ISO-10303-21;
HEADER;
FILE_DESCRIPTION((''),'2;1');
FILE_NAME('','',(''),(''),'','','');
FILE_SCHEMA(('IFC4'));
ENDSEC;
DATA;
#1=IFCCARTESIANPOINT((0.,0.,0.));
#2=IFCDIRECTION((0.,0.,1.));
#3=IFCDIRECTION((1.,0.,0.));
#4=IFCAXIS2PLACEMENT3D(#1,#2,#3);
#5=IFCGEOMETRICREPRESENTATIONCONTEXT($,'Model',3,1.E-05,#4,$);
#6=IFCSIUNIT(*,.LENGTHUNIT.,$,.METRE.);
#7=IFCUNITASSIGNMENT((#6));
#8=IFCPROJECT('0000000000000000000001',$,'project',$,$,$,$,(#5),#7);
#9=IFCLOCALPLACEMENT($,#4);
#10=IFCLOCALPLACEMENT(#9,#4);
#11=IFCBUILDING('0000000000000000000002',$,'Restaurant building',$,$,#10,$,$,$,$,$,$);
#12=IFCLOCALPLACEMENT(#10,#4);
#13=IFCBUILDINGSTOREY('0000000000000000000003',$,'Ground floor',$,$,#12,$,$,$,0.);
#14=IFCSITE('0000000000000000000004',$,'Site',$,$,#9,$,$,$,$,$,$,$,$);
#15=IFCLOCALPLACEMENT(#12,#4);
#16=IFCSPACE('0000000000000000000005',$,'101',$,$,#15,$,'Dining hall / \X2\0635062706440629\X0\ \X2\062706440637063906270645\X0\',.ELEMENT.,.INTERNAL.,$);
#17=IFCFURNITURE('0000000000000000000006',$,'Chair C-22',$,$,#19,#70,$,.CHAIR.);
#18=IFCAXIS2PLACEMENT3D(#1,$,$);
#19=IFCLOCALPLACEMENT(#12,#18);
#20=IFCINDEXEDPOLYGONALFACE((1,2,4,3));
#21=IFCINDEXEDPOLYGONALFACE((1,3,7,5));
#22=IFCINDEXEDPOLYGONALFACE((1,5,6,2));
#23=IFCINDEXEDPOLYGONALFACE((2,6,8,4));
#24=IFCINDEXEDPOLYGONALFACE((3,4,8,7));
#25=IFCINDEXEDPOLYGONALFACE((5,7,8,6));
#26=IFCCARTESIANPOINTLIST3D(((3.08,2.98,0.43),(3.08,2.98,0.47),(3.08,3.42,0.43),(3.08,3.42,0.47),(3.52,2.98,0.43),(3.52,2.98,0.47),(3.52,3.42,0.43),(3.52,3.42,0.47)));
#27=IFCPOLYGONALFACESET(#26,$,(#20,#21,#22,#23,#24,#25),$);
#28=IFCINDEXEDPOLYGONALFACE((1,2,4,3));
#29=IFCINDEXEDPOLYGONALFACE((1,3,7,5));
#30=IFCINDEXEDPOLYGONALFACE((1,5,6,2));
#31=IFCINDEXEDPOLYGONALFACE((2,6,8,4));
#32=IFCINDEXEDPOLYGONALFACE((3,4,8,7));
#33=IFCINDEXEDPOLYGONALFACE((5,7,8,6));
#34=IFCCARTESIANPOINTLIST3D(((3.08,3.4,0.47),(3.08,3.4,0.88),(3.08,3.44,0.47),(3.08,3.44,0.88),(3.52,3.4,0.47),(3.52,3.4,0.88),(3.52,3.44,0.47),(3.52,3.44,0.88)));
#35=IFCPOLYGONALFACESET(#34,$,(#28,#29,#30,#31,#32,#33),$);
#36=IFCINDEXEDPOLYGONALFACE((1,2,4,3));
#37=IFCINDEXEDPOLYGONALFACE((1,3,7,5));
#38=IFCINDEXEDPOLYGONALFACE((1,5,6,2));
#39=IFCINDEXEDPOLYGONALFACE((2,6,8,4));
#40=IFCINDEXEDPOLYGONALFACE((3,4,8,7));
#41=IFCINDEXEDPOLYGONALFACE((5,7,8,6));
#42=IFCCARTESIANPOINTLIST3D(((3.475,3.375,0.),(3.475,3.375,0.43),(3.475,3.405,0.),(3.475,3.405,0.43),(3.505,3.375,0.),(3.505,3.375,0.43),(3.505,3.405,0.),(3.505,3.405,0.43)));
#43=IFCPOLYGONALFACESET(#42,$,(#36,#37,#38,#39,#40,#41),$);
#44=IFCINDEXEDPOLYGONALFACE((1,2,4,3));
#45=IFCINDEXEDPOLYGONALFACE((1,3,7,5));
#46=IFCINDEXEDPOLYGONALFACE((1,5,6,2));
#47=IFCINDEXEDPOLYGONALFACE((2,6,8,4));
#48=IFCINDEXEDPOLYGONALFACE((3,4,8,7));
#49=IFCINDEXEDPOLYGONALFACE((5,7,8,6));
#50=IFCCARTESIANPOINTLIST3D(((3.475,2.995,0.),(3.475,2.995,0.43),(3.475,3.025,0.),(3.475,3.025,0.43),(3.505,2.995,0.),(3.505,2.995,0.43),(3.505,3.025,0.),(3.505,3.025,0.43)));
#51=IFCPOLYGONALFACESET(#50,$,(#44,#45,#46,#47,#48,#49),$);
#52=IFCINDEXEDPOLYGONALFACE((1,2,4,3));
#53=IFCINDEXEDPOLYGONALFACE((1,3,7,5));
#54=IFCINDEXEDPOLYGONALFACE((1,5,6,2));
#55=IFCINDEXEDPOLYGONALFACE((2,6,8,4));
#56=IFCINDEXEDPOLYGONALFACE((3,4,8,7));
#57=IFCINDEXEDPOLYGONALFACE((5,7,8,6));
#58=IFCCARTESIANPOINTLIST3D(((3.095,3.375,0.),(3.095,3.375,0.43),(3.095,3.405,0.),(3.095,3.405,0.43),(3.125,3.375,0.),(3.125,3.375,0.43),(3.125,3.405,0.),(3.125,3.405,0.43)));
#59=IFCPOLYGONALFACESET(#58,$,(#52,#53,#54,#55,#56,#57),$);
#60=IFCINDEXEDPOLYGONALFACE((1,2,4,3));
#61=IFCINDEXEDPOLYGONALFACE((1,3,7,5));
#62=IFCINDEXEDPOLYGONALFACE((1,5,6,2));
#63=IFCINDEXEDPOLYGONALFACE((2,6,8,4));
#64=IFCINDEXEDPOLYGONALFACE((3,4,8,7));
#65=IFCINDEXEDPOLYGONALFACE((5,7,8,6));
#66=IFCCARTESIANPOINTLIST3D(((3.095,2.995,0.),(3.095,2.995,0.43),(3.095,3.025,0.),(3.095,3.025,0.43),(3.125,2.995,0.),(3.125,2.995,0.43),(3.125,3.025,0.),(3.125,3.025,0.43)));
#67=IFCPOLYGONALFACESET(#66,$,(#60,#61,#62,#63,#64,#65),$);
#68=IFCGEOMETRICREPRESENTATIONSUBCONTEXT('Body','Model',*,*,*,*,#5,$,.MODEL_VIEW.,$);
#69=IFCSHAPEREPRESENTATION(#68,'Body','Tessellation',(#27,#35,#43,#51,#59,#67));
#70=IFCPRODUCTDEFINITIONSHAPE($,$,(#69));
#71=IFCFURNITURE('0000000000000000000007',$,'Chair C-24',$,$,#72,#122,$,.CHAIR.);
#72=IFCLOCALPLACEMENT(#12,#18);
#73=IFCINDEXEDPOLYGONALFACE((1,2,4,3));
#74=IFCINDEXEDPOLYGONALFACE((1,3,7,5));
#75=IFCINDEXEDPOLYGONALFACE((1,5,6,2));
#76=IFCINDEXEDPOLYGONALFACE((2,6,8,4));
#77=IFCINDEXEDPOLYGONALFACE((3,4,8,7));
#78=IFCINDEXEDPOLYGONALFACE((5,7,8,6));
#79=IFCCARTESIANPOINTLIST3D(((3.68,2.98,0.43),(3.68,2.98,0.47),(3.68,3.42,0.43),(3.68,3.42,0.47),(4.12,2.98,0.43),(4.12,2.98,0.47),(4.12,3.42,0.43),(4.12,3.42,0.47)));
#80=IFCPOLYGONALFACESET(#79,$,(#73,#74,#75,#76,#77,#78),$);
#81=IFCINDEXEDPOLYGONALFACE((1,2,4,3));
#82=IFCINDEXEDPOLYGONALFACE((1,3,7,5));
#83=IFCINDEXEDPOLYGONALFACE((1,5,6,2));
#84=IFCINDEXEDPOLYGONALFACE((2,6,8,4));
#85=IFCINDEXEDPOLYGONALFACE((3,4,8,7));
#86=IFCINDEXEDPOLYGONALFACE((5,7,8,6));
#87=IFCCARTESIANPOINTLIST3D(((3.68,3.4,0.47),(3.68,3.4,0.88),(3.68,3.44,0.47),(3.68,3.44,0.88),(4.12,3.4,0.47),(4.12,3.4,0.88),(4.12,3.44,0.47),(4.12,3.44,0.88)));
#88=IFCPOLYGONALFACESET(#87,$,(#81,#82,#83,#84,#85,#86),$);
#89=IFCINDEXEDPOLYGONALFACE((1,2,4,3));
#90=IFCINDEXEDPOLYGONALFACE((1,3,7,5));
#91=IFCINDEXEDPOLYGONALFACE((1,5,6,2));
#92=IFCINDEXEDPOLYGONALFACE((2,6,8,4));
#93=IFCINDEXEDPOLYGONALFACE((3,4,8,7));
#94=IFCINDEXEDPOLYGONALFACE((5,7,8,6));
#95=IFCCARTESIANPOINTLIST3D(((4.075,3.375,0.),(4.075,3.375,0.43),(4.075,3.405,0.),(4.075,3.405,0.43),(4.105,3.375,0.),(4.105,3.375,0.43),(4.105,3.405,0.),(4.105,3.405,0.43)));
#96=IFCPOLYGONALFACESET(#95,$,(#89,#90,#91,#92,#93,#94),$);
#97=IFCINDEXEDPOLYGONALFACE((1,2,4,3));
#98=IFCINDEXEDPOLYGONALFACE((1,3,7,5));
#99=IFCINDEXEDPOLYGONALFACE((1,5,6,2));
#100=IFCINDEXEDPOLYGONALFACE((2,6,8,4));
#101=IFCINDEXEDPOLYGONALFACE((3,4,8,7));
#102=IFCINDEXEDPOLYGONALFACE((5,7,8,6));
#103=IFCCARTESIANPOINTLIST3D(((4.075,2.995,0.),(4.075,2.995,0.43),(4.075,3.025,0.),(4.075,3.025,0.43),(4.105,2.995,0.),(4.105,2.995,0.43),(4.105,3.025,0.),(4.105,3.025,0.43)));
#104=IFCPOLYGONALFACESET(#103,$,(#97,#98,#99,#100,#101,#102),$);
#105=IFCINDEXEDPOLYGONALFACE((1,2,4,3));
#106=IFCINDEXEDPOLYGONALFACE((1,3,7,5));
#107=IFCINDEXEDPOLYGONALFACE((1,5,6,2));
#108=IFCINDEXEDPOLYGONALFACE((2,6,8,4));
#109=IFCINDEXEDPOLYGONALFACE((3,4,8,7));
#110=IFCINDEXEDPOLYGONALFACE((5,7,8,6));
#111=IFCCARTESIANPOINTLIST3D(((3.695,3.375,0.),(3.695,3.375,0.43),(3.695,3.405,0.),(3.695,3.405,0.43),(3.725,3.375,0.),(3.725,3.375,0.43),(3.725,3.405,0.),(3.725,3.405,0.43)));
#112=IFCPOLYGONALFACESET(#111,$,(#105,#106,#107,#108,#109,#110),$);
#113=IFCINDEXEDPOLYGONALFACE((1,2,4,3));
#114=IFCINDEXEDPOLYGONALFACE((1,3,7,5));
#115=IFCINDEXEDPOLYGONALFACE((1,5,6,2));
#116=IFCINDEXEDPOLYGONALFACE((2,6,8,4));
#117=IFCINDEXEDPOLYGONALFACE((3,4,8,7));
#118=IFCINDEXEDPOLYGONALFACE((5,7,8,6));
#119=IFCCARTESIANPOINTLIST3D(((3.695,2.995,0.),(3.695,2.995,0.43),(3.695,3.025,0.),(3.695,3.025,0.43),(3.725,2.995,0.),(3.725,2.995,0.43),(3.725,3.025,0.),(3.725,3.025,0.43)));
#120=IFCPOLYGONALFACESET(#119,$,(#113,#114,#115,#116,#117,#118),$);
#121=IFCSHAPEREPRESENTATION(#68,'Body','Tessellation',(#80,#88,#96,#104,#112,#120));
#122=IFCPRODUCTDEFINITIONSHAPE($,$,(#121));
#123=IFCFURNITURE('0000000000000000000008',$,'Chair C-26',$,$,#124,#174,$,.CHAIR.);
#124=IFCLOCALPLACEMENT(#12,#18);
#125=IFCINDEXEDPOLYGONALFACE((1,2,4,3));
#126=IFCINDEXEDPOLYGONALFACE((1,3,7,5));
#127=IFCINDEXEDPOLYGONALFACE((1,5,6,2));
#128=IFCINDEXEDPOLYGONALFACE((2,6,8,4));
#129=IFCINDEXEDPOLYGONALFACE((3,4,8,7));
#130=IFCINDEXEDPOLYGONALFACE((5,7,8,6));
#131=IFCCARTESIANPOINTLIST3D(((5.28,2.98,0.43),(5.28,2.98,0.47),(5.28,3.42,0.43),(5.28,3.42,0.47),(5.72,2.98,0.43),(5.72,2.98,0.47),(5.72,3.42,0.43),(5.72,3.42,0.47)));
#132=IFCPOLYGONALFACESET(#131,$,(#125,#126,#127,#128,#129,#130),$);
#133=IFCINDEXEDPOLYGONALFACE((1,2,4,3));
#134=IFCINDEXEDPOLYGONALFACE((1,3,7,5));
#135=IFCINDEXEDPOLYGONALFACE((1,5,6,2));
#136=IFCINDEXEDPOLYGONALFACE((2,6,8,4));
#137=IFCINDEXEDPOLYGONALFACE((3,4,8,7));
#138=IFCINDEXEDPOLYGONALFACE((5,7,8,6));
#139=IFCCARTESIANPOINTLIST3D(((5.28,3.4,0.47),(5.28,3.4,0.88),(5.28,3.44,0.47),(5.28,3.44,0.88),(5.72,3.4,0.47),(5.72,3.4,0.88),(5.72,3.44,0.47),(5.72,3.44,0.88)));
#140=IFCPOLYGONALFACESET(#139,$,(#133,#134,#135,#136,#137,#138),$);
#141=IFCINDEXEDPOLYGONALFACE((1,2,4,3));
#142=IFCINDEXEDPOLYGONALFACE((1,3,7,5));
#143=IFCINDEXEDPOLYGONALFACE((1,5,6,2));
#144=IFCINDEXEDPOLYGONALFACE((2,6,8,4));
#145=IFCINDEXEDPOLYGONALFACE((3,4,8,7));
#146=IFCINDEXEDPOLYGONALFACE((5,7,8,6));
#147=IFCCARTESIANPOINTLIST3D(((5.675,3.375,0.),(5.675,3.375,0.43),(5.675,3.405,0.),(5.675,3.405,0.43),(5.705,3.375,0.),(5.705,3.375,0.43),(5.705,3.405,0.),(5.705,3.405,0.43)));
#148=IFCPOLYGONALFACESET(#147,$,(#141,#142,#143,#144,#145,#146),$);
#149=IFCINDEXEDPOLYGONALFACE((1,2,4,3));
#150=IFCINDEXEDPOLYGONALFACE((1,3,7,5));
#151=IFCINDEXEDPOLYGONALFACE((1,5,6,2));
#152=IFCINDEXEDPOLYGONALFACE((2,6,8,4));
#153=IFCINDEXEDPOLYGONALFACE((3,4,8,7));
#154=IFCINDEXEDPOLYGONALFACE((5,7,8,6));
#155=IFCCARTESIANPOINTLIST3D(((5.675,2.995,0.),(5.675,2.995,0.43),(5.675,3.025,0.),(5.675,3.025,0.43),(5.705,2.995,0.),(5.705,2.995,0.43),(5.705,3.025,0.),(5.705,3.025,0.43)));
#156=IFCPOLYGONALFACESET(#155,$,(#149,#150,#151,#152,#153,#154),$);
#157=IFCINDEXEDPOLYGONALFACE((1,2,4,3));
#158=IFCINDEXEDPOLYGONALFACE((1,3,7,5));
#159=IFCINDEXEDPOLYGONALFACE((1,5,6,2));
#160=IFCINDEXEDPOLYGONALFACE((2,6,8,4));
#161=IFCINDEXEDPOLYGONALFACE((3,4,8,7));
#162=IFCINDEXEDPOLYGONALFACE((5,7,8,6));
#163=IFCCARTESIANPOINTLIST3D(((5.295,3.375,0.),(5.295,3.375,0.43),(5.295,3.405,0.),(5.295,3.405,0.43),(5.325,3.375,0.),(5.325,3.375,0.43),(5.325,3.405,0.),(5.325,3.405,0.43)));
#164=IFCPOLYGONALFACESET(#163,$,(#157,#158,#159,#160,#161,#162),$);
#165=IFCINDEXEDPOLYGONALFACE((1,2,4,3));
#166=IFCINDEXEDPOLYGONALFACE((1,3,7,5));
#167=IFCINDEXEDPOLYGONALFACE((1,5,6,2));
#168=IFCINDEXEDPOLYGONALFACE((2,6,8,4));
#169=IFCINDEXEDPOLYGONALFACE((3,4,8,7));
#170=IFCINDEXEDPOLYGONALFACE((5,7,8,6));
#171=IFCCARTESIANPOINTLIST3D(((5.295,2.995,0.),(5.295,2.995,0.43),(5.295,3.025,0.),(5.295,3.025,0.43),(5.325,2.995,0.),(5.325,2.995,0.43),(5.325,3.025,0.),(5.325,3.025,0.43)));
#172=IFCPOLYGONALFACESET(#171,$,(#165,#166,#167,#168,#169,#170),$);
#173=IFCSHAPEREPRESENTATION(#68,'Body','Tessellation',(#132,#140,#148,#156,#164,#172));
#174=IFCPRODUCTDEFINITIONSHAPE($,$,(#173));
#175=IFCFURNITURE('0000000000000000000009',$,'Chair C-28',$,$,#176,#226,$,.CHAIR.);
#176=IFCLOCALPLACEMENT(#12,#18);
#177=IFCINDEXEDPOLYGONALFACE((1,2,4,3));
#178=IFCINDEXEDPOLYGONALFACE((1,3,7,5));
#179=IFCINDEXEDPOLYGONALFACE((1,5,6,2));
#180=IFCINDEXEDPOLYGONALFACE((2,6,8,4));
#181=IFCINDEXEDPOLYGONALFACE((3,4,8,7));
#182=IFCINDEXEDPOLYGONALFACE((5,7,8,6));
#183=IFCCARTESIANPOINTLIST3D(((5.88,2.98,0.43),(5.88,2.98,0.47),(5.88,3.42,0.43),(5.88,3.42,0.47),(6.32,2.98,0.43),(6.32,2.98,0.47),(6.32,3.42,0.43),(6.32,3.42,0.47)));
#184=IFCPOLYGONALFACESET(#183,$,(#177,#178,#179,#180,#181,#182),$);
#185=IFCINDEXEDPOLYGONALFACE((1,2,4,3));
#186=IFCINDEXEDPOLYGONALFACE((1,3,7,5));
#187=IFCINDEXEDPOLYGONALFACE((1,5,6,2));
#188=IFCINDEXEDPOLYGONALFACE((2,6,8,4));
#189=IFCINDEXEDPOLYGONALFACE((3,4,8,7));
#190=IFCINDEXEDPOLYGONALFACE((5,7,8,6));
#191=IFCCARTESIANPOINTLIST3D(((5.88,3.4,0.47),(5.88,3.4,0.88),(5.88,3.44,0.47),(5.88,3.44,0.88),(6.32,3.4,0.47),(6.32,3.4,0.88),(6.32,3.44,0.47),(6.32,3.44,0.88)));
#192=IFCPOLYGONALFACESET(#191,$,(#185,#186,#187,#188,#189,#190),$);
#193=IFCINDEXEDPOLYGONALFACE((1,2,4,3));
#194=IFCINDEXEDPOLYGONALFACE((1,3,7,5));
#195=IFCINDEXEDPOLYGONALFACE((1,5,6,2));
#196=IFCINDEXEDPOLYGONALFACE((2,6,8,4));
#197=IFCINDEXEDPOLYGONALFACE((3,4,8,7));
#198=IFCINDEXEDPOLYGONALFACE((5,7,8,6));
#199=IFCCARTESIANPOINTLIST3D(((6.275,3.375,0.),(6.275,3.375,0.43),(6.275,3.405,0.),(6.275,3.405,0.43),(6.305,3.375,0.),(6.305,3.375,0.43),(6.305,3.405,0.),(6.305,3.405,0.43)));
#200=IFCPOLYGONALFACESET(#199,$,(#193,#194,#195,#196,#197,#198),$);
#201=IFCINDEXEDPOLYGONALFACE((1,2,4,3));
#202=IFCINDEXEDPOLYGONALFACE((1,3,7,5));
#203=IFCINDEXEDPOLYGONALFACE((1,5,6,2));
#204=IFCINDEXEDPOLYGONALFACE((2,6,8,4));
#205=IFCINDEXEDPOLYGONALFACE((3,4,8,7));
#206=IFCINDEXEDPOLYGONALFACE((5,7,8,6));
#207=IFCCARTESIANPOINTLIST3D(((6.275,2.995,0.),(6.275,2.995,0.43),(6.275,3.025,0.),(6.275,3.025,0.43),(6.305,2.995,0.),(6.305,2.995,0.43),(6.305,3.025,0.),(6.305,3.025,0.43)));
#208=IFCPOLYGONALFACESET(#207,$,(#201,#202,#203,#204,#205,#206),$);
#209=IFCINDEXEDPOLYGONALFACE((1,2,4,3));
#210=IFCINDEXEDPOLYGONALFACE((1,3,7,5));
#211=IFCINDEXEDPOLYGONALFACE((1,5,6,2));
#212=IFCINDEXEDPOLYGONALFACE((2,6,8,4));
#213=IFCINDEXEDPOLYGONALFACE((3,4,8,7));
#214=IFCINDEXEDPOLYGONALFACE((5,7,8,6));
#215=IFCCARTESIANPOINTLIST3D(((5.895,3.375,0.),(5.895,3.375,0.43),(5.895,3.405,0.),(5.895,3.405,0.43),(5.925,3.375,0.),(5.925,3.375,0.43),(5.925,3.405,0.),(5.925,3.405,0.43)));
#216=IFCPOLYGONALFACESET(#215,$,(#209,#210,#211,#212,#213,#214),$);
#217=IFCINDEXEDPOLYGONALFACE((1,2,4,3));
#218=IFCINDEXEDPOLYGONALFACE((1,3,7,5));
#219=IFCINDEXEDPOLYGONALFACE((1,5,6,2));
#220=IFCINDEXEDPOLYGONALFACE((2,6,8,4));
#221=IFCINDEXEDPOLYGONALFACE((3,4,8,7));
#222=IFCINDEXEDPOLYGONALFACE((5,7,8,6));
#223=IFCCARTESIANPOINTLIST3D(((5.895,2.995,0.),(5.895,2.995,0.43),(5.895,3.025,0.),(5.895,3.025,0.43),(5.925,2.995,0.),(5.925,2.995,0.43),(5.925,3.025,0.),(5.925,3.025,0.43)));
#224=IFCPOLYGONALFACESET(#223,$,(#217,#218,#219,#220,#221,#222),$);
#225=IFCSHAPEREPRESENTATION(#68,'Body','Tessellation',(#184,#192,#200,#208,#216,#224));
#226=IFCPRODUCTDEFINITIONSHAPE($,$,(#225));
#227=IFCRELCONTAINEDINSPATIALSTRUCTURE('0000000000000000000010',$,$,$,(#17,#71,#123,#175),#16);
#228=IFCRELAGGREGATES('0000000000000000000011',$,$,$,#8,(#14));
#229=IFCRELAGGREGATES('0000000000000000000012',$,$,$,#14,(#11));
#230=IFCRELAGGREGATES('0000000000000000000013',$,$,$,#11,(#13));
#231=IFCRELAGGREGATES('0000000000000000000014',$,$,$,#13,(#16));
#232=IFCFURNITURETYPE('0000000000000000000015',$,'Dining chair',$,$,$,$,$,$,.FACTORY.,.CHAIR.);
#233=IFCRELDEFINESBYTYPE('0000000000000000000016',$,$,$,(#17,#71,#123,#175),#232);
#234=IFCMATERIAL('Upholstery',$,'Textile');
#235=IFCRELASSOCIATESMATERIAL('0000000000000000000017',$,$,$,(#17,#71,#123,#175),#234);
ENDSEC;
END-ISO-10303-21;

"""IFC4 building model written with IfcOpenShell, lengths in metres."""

from ifc_helpers import new_model, si_unit, frame, origin, origin_with_axes, origin_2d, place, context, subcontext, project, spatial, rectangle, extrude, source, transform, mapped, material, type_object, type_shapes, element, save


model = new_model("IFC4")

# Units and contexts
model_context = context("Model", 3, precision=1e-05, world=origin_with_axes())
body_context = subcontext(model_context, "Body", "Model", "MODEL_VIEW")
ifc_project = project(units=[si_unit("LENGTHUNIT", "METRE")], contexts=[model_context])

# Site, building, storey, space
site_placement = place(None, origin_with_axes())
site = spatial("IfcSite", under=ifc_project, at=site_placement, Name="Site")
building_placement = place(site_placement, origin_with_axes())
building = spatial("IfcBuilding", under=site, at=building_placement, Name="Restaurant building")
storey_placement = place(building_placement, origin_with_axes())
storey = spatial("IfcBuildingStorey", under=building, at=storey_placement, Name="Ground floor", Elevation=0.0)
space_placement = place(storey_placement, origin_with_axes())
space = spatial("IfcSpace", under=storey, at=space_placement, Name="101", LongName="Dining hall / صالة الطعام", CompositionType="ELEMENT", PredefinedType="INTERNAL")

# Furniture
ifc_material_1 = material(Name="Upholstery", Category="Textile")
furniture_type_1 = type_object("IfcFurnitureType", Name="Dining chair", AssemblyPlace="FACTORY", PredefinedType="CHAIR")
shared_shape_1 = source(origin(), body_context, "Body", "SweptSolid", [
    extrude(rectangle(XDim=0.44, YDim=0.44, at=origin_2d()), frame((0.0, 0.0, 0.43)), (0.0, 0.0, 1.0), 0.04),
    extrude(rectangle(XDim=0.44, YDim=0.04, at=origin_2d()), frame((0.0, -0.22, 0.47)), (0.0, 0.0, 1.0), 0.41),
    extrude(rectangle(XDim=0.03, YDim=0.03, at=origin_2d()), frame((-0.19, -0.19, 0.0)), (0.0, 0.0, 1.0), 0.43),
    extrude(rectangle(XDim=0.03, YDim=0.03, at=origin_2d()), frame((-0.19, 0.19, 0.0)), (0.0, 0.0, 1.0), 0.43),
    extrude(rectangle(XDim=0.03, YDim=0.03, at=origin_2d()), frame((0.19, -0.19, 0.0)), (0.0, 0.0, 1.0), 0.43),
    extrude(rectangle(XDim=0.03, YDim=0.03, at=origin_2d()), frame((0.19, 0.19, 0.0)), (0.0, 0.0, 1.0), 0.43),
])
type_shapes(furniture_type_1, [shared_shape_1])
for number, where, z_axis, x_axis, name in (
    (1, (3.3, 3.2, 0.0), (0.0, 0.0, 1.0), (-1.0, 0.0, 0.0), "Chair C-22"),
    (2, (3.9, 3.2, 0.0), (0.0, 0.0, 1.0), (-1.0, 0.0, 0.0), "Chair C-24"),
    (3, (5.5, 3.2, 0.0), (0.0, 0.0, 1.0), (-1.0, 0.0, 0.0), "Chair C-26"),
    (4, (6.1, 3.2, 0.0), (0.0, 0.0, 1.0), (-1.0, 0.0, 0.0), "Chair C-28"),
):
    element("IfcFurniture", number, at=place(storey_placement, frame(where, z_axis=z_axis, x_axis=x_axis)), inside=space, type_object=furniture_type_1, material=ifc_material_1, Name=name, PredefinedType="CHAIR", context=body_context, shape_type="MappedRepresentation", body=[
        mapped(shared_shape_1, transform((0.0, 0.0, 0.0))),
    ])

save(model, "model.ifc")
